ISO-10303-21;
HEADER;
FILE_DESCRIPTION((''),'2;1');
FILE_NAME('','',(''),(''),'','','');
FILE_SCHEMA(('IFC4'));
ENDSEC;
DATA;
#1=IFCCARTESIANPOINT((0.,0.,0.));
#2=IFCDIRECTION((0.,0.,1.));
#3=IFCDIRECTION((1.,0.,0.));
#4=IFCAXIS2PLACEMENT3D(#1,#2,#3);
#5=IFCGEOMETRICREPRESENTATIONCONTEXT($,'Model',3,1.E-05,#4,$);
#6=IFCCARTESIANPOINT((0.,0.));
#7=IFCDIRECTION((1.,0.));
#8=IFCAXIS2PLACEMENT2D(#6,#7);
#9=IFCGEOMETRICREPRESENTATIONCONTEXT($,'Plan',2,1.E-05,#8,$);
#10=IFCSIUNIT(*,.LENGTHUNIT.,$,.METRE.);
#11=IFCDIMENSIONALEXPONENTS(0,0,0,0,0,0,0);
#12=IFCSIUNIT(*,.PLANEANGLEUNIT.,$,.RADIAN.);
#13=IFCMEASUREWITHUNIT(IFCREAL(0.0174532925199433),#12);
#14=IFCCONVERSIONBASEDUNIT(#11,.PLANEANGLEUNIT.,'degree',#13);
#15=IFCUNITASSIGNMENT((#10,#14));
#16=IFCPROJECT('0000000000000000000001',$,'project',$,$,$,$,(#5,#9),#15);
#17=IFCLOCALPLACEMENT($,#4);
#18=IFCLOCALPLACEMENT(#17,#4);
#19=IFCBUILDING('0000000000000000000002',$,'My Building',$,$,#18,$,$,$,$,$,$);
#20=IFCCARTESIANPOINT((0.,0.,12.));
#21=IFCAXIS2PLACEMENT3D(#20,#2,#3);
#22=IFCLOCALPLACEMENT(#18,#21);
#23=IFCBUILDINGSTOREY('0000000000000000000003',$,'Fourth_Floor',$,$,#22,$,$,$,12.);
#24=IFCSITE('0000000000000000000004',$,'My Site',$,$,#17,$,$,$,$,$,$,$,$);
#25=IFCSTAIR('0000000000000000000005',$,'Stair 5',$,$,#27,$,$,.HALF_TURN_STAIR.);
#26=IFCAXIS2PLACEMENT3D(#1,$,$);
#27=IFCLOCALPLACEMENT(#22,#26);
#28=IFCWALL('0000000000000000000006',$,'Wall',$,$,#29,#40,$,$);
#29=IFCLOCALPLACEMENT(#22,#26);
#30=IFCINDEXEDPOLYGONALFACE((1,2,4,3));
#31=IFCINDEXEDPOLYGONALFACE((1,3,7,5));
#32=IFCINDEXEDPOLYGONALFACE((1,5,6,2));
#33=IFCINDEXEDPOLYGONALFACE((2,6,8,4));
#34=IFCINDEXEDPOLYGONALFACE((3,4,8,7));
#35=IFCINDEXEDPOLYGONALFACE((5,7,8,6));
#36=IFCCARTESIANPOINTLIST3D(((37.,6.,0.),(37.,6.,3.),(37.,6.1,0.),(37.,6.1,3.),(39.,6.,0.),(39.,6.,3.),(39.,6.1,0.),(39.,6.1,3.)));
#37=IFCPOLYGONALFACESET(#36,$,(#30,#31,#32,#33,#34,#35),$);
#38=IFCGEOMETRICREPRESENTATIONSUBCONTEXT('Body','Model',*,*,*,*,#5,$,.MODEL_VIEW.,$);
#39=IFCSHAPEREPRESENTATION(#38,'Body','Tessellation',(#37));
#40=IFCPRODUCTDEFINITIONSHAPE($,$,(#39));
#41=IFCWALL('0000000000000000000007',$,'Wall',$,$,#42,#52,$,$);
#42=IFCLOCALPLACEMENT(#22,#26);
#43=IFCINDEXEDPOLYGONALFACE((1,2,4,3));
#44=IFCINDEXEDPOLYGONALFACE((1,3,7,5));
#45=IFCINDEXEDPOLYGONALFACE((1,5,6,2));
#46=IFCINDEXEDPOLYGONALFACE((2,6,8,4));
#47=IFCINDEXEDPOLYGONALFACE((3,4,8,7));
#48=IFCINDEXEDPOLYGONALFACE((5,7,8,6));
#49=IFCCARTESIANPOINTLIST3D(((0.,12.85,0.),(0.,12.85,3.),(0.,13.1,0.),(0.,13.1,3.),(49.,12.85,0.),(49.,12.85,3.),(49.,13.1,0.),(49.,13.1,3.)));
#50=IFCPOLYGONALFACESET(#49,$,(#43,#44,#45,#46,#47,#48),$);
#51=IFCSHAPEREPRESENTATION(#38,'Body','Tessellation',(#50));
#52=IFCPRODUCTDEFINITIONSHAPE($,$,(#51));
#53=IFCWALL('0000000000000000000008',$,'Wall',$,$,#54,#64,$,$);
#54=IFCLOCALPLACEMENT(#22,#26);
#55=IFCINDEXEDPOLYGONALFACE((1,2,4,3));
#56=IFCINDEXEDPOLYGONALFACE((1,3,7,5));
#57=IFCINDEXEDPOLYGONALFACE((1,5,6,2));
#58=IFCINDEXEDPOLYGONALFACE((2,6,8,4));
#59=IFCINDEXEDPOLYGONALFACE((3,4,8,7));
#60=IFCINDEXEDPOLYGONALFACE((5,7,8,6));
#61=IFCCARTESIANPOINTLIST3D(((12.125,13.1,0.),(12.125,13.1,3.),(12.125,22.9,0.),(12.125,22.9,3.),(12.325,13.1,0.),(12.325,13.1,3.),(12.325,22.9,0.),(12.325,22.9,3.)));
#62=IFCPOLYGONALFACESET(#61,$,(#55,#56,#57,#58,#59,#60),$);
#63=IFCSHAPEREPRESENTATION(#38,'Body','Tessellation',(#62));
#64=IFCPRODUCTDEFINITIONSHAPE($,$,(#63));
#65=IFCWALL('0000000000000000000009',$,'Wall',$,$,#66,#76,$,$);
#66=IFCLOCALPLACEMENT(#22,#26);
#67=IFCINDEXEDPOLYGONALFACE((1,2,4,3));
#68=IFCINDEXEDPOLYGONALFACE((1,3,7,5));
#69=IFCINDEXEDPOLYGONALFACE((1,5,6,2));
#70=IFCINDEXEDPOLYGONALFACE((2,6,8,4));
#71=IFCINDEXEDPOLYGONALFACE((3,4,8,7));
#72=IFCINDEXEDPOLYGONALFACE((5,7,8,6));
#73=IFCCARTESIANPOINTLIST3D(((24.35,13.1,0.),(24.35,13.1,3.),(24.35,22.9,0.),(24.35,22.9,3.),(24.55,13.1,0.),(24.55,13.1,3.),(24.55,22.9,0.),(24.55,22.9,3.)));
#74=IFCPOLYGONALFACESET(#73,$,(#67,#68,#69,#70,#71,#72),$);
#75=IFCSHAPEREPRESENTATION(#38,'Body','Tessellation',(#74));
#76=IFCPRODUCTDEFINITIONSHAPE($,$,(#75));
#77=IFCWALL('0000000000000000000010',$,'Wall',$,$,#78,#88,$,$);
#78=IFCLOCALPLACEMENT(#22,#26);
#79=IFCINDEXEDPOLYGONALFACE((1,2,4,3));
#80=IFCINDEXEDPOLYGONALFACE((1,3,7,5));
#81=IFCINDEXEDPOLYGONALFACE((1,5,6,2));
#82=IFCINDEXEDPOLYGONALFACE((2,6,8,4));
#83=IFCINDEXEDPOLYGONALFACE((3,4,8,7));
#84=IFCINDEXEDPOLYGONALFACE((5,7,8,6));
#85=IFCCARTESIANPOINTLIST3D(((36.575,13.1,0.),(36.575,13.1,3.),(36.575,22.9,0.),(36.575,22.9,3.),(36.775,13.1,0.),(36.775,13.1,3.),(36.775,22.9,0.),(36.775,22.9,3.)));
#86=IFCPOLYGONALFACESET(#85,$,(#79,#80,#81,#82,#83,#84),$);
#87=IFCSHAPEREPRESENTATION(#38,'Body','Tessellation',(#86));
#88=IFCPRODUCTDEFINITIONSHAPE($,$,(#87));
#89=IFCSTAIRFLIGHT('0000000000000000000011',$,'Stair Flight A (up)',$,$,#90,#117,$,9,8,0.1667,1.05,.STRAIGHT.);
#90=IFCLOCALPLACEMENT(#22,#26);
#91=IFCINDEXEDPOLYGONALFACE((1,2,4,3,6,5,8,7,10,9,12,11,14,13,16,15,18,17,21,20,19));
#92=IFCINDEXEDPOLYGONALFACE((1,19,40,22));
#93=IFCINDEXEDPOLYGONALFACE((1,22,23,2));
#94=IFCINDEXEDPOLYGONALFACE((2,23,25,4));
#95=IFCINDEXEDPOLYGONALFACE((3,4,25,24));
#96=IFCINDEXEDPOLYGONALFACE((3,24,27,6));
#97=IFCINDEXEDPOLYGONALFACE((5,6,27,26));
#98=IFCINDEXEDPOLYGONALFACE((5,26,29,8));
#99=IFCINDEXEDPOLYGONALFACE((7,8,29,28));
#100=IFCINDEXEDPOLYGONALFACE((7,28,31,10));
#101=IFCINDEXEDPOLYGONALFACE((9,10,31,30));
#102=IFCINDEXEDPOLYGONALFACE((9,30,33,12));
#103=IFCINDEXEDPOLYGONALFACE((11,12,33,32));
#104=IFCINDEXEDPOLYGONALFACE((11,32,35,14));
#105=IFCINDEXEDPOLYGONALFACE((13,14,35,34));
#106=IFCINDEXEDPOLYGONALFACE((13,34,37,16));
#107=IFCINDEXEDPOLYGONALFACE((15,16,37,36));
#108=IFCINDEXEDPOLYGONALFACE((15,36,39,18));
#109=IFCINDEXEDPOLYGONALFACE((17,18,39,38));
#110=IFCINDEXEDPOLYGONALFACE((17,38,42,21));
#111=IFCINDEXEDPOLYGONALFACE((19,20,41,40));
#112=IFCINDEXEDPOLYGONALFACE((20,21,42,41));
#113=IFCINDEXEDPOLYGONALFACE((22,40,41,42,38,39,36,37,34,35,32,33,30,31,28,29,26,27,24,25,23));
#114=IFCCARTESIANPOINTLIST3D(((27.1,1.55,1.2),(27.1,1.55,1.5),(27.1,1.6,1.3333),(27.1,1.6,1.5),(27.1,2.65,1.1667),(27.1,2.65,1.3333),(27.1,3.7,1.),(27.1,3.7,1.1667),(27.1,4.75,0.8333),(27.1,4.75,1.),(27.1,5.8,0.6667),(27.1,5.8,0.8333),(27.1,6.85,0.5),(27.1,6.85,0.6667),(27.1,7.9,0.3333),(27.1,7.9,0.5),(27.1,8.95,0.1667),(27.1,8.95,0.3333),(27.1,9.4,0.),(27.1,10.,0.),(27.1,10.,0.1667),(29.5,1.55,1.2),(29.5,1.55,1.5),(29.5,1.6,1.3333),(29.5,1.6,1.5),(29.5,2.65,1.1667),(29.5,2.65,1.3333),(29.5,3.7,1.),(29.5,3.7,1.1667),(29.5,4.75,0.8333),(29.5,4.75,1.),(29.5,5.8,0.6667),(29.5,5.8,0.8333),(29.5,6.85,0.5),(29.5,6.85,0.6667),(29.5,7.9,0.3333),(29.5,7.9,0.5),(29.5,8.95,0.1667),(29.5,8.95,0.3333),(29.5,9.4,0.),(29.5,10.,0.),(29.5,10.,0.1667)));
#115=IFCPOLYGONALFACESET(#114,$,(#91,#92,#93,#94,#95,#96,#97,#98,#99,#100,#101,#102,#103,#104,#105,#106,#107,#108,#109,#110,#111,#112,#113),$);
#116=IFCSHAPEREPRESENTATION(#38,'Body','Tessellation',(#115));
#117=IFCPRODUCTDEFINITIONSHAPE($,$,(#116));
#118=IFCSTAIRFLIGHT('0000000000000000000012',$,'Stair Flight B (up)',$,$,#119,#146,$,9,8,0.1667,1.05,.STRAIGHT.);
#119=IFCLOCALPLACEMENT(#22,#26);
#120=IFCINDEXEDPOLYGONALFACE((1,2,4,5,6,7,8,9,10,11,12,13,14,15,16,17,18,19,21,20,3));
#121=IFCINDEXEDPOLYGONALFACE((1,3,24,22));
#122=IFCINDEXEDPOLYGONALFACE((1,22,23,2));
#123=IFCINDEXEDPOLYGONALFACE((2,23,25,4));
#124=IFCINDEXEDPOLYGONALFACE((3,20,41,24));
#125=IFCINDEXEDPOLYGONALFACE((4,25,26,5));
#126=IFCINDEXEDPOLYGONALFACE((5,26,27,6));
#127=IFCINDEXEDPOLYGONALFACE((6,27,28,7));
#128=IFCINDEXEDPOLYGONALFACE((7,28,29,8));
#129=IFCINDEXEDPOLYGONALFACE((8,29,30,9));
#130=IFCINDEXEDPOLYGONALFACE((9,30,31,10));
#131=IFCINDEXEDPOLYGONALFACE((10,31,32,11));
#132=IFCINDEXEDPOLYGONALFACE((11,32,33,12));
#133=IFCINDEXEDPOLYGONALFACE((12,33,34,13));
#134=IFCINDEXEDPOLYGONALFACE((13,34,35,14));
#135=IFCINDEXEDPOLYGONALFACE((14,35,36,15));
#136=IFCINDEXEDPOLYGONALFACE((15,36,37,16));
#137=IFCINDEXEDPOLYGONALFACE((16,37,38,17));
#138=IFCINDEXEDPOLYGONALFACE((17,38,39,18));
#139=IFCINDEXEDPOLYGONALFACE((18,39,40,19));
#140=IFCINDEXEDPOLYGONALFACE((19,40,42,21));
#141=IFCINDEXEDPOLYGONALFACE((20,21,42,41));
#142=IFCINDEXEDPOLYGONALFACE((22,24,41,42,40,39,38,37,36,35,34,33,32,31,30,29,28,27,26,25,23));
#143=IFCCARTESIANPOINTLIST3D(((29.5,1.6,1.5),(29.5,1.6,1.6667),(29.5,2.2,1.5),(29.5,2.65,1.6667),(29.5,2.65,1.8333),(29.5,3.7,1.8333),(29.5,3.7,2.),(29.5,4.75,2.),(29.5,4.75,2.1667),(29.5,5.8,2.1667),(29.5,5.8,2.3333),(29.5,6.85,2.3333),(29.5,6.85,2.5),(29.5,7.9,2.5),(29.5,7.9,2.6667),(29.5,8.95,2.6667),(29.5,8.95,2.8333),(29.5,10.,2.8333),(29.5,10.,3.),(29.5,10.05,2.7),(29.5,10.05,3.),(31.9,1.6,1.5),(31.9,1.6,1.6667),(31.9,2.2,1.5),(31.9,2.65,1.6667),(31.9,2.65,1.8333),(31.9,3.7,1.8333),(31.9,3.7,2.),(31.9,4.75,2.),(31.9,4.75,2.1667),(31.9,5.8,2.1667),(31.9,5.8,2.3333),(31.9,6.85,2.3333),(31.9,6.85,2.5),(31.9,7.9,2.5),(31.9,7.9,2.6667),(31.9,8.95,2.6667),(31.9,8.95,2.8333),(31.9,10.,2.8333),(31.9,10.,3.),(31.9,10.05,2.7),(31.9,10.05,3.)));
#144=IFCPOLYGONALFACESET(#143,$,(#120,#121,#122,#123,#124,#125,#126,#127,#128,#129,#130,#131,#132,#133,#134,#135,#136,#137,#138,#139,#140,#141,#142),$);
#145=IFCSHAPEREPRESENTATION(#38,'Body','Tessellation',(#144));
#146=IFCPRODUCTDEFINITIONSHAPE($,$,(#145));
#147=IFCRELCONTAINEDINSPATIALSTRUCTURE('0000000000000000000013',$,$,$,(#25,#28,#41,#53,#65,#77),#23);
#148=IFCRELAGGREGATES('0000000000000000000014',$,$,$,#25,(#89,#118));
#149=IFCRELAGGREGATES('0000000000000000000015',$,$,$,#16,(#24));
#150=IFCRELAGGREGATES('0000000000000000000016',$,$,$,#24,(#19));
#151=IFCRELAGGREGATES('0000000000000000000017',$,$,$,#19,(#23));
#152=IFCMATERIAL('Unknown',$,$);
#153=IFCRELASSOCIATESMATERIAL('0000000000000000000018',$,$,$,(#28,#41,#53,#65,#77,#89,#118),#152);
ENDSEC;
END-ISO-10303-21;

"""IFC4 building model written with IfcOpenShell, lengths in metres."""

from ifc_helpers import new_model, entity, si_unit, converted_unit, frame, frame_2d, origin, origin_with_axes, origin_2d_with_axis, place, context, subcontext, project, spatial, polyline, rectangle, outline, extrude, material, element, aggregate, save


model = new_model("IFC4")

# Units and contexts
model_context = context("Model", 3, precision=1e-05, world=origin_with_axes())
plan_context = context("Plan", 2, precision=1e-05, world=origin_2d_with_axis())
body_context = subcontext(model_context, "Body", "Model", "MODEL_VIEW")
ifc_project = project(units=[si_unit("LENGTHUNIT", "METRE"), converted_unit("PLANEANGLEUNIT", "degree", entity("IfcReal", 0.0174532925199433), si_unit("PLANEANGLEUNIT", "RADIAN"), dimensions=[0, 0, 0, 0, 0, 0, 0])], contexts=[model_context, plan_context])

# Site, building, storey
site_placement = place(None, origin_with_axes())
site = spatial("IfcSite", under=ifc_project, at=site_placement, Name="My Site")
building_placement = place(site_placement, origin_with_axes())
building = spatial("IfcBuilding", under=site, at=building_placement, Name="My Building")
storey_placement = place(building_placement, frame((0.0, 0.0, 12.0), z_axis=(0.0, 0.0, 1.0), x_axis=(1.0, 0.0, 0.0)))
storey = spatial("IfcBuildingStorey", under=building, at=storey_placement, Name="Fourth_Floor", Elevation=12.0)

# Shared definitions
ifc_material = material(Name="Unknown")

# Stair
stair_placement = place(storey_placement, origin_with_axes())
stair = element("IfcStair", 1, at=stair_placement, inside=storey, Name="Stair 5", PredefinedType="HALF_TURN_STAIR")

# Walls
wall_1_placement = place(storey_placement, origin_with_axes())
element("IfcWall", 2, at=wall_1_placement, inside=storey, material=ifc_material, Name="Wall", context=body_context, shape_type="SweptSolid", body=[
    extrude(rectangle(XDim=2.0, YDim=0.1, at=frame_2d((38.0, 6.05))), origin(), (0.0, 0.0, 1.0), 3.0),
])
wall_2_placement = place(storey_placement, origin_with_axes())
element("IfcWall", 3, at=wall_2_placement, inside=storey, material=ifc_material, Name="Wall", context=body_context, shape_type="SweptSolid", body=[
    extrude(rectangle(XDim=49.0, YDim=0.25, at=frame_2d((24.5, 12.975))), origin(), (0.0, 0.0, 1.0), 3.0),
])
wall_3_placement = place(storey_placement, origin_with_axes())
element("IfcWall", 4, at=wall_3_placement, inside=storey, material=ifc_material, Name="Wall", context=body_context, shape_type="SweptSolid", body=[
    extrude(rectangle(XDim=0.2, YDim=9.8, at=frame_2d((12.225, 18.0))), origin(), (0.0, 0.0, 1.0), 3.0),
])
wall_4_placement = place(storey_placement, origin_with_axes())
element("IfcWall", 5, at=wall_4_placement, inside=storey, material=ifc_material, Name="Wall", context=body_context, shape_type="SweptSolid", body=[
    extrude(rectangle(XDim=0.2, YDim=9.8, at=frame_2d((24.45, 18.0))), origin(), (0.0, 0.0, 1.0), 3.0),
])
wall_5_placement = place(storey_placement, origin_with_axes())
element("IfcWall", 6, at=wall_5_placement, inside=storey, material=ifc_material, Name="Wall", context=body_context, shape_type="SweptSolid", body=[
    extrude(rectangle(XDim=0.2, YDim=9.8, at=frame_2d((36.675, 18.0))), origin(), (0.0, 0.0, 1.0), 3.0),
])

# Stair flights
stair_flight_1_placement = place(stair_placement, origin_with_axes())
stair_flight_1 = element("IfcStairFlight", 7, at=stair_flight_1_placement, material=ifc_material, Name="Stair Flight A (up)", NumberOfRisers=9, NumberOfTreads=8, PredefinedType="STRAIGHT", RiserHeight=0.1667, TreadLength=1.05, context=body_context, shape_type="SweptSolid", body=[
    extrude(outline(polyline([(10.0, 0.0), (10.0, 0.1667), (8.95, 0.1667), (8.95, 0.3333), (7.9, 0.3333), (7.9, 0.3333), (7.9, 0.5), (6.85, 0.5), (6.85, 0.5), (6.85, 0.6667), (5.8, 0.6667), (5.8, 0.8333), (4.75, 0.8333), (4.75, 1.0), (3.7, 1.0), (3.7, 1.0), (3.7, 1.1667), (2.65, 1.1667), (2.65, 1.3333), (1.6, 1.3333), (1.6, 1.3333), (1.6, 1.5), (1.55, 1.5), (1.55, 1.2), (9.4, 0.0), (10.0, 0.0)])), frame((27.1, 0.0, 0.0), z_axis=(1.0, 0.0, 0.0), x_axis=(0.0, 1.0, 0.0)), (0.0, 0.0, 1.0), 2.4),
])
stair_flight_2_placement = place(stair_placement, origin_with_axes())
stair_flight_2 = element("IfcStairFlight", 8, at=stair_flight_2_placement, material=ifc_material, Name="Stair Flight B (up)", NumberOfRisers=9, NumberOfTreads=8, PredefinedType="STRAIGHT", RiserHeight=0.1667, TreadLength=1.05, context=body_context, shape_type="SweptSolid", body=[
    extrude(outline(polyline([(1.6, 1.5), (1.6, 1.6667), (2.65, 1.6667), (2.65, 1.8333), (3.7, 1.8333), (3.7, 1.8333), (3.7, 2.0), (4.75, 2.0), (4.75, 2.1667), (5.8, 2.1667), (5.8, 2.3333), (6.85, 2.3333), (6.85, 2.5), (7.9, 2.5), (7.9, 2.5), (7.9, 2.6667), (8.95, 2.6667), (8.95, 2.6667), (8.95, 2.8333), (10.0, 2.8333), (10.0, 3.0), (10.05, 3.0), (10.05, 2.7), (2.2, 1.5), (1.6, 1.5)])), frame((29.5, 0.0, 0.0), z_axis=(1.0, 0.0, 0.0), x_axis=(0.0, 1.0, 0.0)), (0.0, 0.0, 1.0), 2.4),
])
aggregate(stair, [stair_flight_1, stair_flight_2])

save(model, "model.ifc")
